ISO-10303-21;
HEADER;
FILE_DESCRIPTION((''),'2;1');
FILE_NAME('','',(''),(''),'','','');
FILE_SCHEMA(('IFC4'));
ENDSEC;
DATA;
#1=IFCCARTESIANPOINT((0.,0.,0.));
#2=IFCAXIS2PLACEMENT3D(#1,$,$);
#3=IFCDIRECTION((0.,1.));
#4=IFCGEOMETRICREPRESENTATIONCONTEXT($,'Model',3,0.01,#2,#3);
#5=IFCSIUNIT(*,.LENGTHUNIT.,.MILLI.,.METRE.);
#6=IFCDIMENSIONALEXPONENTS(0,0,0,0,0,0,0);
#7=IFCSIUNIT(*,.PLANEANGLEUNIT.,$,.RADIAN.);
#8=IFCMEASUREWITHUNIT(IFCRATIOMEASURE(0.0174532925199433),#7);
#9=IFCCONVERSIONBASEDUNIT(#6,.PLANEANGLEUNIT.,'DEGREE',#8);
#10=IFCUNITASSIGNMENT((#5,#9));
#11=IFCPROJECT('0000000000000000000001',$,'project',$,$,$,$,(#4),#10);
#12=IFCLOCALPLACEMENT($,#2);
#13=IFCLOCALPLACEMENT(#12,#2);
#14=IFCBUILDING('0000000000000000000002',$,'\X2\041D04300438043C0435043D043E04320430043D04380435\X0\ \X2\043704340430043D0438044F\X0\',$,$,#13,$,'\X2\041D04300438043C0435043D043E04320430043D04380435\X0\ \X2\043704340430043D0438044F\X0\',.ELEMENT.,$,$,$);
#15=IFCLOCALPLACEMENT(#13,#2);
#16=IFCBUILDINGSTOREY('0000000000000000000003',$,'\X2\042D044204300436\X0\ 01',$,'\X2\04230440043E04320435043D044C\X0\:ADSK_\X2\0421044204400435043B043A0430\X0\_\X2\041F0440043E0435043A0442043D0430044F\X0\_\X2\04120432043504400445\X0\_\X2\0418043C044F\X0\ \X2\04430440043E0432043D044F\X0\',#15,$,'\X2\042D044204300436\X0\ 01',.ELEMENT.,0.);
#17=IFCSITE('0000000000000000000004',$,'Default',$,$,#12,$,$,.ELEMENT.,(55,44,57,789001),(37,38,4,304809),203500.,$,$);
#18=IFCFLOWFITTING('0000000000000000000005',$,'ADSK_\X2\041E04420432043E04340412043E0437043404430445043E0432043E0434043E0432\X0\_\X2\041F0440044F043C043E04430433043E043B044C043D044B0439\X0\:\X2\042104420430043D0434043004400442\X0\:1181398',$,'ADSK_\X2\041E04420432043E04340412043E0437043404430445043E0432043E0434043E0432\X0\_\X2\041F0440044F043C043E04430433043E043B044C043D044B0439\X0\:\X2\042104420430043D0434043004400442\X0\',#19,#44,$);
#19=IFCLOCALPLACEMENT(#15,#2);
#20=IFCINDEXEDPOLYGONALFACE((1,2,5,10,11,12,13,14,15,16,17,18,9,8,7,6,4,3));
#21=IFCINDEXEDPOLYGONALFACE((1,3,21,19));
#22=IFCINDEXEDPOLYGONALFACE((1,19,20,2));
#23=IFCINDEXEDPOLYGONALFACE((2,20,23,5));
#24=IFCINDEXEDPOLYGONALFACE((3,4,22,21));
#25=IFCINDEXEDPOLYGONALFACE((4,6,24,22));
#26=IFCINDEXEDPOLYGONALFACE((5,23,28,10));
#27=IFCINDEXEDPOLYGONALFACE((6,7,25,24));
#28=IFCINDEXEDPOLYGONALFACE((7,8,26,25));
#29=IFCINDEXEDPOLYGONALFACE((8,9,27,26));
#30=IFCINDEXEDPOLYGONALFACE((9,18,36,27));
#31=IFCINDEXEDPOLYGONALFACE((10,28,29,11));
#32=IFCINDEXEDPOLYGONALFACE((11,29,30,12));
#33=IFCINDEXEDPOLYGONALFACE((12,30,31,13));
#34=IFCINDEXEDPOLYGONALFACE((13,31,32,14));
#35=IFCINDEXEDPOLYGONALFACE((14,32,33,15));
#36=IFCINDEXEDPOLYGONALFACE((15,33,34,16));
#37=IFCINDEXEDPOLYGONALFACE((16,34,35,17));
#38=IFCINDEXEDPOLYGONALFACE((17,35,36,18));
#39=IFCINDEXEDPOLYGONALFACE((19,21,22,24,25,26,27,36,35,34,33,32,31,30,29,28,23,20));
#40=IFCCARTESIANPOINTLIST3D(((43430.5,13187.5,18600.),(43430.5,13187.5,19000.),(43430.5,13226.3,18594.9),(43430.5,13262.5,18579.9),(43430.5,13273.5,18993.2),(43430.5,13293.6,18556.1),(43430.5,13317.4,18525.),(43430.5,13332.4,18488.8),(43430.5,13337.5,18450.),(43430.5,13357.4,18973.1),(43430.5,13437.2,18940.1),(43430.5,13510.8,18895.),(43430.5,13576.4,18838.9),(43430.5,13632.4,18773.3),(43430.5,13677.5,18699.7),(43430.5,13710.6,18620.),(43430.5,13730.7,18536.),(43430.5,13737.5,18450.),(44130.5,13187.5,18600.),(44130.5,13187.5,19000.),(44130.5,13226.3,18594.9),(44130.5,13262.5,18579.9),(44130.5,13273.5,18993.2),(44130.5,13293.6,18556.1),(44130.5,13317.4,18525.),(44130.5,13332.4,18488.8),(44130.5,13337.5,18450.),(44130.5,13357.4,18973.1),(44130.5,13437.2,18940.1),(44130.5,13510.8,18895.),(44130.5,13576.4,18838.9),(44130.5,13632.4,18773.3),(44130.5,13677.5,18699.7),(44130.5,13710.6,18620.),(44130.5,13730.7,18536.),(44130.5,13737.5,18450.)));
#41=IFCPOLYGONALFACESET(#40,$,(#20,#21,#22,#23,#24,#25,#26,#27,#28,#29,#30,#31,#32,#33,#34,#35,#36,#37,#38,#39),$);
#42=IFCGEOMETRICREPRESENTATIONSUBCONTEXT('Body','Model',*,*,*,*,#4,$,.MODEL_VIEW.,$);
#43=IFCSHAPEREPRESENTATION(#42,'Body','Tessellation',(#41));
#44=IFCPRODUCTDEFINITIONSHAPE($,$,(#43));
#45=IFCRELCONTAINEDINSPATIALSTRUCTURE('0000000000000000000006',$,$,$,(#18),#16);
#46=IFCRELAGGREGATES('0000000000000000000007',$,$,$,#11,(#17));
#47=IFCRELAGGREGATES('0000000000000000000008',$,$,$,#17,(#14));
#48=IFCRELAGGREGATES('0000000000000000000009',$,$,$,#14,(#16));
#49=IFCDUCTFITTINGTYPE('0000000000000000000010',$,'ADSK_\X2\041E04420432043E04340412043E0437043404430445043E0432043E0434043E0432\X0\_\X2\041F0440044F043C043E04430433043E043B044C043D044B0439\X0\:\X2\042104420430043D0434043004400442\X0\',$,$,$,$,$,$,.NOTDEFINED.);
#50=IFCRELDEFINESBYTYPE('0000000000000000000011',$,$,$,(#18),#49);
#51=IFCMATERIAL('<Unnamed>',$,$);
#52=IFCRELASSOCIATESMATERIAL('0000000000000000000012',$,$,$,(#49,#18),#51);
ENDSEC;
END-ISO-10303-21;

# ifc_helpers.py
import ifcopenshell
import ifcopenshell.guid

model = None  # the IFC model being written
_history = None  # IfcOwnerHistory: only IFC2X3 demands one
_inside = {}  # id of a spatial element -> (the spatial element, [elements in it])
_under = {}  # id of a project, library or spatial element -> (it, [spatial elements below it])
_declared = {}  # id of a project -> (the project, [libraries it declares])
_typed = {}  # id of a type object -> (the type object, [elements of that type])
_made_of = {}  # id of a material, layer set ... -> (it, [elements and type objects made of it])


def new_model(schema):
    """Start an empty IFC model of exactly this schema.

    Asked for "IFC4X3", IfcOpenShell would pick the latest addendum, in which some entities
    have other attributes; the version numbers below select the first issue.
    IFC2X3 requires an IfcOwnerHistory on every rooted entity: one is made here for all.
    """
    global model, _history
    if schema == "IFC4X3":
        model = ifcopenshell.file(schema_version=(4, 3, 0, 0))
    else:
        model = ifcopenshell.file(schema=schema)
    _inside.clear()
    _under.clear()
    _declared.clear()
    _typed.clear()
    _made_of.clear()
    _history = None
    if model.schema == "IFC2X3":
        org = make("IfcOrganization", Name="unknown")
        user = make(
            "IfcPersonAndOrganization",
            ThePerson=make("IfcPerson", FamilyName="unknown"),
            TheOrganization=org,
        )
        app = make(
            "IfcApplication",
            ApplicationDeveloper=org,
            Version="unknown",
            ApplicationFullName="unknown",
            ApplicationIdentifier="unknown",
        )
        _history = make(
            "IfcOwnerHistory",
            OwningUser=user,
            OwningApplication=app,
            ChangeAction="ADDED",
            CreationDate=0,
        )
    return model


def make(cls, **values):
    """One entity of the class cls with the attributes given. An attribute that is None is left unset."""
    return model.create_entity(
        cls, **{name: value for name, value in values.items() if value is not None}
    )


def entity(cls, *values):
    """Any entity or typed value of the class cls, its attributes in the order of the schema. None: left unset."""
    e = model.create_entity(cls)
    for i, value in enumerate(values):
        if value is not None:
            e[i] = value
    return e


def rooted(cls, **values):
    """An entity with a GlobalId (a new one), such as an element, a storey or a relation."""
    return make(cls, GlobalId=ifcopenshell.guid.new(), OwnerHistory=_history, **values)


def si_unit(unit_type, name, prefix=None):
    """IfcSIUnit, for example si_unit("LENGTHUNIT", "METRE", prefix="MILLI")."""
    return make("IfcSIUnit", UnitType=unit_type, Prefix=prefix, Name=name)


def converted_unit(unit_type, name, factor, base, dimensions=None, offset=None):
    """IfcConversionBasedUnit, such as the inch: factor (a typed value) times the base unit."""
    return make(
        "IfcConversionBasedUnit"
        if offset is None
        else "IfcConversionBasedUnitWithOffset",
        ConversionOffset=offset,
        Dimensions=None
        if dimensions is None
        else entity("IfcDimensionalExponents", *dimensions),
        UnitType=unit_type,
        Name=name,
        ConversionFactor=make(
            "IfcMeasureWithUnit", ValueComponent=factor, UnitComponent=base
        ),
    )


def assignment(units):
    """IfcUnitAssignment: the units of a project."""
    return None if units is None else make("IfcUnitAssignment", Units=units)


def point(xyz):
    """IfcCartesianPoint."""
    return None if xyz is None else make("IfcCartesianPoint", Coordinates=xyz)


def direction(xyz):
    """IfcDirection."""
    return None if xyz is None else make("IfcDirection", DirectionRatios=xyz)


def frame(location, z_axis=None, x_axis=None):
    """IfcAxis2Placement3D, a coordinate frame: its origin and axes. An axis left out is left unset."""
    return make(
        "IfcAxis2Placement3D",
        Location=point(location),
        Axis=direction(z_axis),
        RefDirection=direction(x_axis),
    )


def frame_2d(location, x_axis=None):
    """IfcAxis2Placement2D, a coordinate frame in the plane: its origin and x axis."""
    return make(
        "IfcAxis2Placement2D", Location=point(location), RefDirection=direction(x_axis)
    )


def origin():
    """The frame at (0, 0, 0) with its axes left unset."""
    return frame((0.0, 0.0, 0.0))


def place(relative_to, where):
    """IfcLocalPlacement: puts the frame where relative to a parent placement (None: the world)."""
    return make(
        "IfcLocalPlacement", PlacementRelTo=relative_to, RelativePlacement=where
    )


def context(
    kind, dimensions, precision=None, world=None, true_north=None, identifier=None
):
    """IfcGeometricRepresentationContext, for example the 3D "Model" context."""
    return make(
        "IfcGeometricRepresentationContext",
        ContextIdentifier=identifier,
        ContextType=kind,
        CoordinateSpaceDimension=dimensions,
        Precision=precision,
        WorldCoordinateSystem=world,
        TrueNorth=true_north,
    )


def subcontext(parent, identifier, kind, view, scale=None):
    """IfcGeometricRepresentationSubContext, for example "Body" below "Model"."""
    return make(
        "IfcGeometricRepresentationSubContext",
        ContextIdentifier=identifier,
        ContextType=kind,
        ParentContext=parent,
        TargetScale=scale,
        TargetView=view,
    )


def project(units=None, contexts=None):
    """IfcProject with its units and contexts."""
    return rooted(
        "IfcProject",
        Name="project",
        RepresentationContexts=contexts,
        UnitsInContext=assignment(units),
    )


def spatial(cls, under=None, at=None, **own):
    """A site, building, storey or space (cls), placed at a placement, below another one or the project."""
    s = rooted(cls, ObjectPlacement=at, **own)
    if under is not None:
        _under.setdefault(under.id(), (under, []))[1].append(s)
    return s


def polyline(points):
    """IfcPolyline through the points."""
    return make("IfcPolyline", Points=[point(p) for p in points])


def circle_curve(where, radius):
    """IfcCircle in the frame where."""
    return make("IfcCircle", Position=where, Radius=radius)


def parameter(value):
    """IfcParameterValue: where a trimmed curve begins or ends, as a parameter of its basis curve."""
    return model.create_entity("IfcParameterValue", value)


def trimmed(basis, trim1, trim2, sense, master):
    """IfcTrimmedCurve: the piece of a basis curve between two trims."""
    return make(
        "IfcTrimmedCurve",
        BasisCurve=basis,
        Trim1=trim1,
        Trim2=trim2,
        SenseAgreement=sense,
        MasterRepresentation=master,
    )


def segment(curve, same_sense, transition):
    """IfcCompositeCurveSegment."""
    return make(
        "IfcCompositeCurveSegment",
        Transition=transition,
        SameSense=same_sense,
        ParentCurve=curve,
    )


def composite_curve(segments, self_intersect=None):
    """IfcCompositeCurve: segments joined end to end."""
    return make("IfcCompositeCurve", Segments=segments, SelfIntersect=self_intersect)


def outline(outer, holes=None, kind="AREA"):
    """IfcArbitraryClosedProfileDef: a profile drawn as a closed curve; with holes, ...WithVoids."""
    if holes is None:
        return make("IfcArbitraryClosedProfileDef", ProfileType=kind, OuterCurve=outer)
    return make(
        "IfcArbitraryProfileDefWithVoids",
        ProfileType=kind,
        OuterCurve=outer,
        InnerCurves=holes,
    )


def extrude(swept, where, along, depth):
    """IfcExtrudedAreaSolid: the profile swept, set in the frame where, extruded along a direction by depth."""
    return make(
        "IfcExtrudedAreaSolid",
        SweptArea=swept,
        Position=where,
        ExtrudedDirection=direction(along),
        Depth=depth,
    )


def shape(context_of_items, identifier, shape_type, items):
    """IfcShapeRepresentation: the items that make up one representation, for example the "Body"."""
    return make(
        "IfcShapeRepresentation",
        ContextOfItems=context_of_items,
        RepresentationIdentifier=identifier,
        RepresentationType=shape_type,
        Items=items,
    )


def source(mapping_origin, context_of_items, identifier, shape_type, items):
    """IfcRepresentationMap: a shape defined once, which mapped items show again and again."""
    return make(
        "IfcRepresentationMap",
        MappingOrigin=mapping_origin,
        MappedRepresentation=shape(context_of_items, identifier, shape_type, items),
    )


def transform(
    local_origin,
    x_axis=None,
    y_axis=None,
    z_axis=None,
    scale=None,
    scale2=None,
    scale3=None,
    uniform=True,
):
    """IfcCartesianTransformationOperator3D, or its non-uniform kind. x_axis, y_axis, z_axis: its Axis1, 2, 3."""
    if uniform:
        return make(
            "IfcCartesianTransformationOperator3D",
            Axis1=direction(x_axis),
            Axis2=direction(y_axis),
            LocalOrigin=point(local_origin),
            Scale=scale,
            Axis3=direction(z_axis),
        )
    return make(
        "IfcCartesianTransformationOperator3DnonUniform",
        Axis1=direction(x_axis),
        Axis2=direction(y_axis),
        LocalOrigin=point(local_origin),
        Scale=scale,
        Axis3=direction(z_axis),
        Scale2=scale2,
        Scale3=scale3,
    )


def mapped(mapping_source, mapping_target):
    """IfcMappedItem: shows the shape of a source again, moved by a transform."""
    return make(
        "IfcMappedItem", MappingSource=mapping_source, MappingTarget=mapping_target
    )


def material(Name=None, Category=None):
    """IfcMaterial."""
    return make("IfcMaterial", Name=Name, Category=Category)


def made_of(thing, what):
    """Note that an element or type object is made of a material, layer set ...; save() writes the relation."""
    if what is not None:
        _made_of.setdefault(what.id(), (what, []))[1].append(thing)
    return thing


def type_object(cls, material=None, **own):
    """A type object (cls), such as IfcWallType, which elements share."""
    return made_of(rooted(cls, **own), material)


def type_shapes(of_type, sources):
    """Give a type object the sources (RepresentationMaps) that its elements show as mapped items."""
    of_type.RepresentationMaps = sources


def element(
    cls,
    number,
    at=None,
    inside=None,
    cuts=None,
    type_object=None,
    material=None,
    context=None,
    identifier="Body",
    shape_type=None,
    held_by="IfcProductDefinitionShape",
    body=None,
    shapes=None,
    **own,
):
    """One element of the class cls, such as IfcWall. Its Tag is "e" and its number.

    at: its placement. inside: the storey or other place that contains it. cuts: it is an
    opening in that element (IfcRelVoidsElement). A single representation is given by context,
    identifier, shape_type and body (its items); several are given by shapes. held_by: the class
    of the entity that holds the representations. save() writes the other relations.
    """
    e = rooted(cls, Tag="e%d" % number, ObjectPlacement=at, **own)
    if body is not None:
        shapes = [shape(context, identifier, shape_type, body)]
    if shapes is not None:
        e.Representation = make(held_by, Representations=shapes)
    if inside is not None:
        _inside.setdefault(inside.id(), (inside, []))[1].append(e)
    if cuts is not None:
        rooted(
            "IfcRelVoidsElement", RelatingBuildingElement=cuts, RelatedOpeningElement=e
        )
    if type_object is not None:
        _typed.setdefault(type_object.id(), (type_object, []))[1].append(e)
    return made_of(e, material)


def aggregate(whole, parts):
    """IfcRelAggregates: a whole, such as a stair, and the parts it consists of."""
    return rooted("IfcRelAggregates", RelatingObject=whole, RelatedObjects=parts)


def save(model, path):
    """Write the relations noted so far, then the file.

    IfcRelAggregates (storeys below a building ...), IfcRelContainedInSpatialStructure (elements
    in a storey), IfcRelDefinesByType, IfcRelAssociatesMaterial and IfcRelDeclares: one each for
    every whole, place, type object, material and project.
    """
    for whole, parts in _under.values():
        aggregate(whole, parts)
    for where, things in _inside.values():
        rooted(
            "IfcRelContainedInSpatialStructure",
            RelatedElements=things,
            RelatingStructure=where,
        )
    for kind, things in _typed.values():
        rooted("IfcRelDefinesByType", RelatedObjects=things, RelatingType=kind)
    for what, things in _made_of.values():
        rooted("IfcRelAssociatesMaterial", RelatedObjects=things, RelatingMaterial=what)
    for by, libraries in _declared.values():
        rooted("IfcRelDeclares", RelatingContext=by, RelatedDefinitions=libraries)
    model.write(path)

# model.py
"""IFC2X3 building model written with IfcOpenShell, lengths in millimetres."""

from ifc_helpers import new_model, entity, si_unit, converted_unit, direction, frame, frame_2d, origin, place, context, subcontext, project, spatial, polyline, circle_curve, parameter, trimmed, segment, composite_curve, outline, extrude, source, transform, mapped, material, type_object, type_shapes, element, save


model = new_model("IFC2X3")

# Units and contexts
model_context = context("Model", 3, precision=0.01, world=origin(), true_north=direction((0.0, 1.0)))
body_context = subcontext(model_context, "Body", "Model", "MODEL_VIEW")
ifc_project = project(units=[si_unit("LENGTHUNIT", "METRE", prefix="MILLI"), converted_unit("PLANEANGLEUNIT", "DEGREE", entity("IfcRatioMeasure", 0.0174532925199433), si_unit("PLANEANGLEUNIT", "RADIAN"), dimensions=[0, 0, 0, 0, 0, 0, 0])], contexts=[model_context])

# Site, building, storey
site_placement = place(None, origin())
site = spatial("IfcSite", under=ifc_project, at=site_placement, Name="Default", CompositionType="ELEMENT", RefLatitude=(55, 44, 57, 789001), RefLongitude=(37, 38, 4, 304809), RefElevation=203500.0)
building_placement = place(site_placement, origin())
building = spatial("IfcBuilding", under=site, at=building_placement, Name="Наименование здания", LongName="Наименование здания", CompositionType="ELEMENT")
storey_placement = place(building_placement, origin())
storey = spatial("IfcBuildingStorey", under=building, at=storey_placement, Name="Этаж 01", ObjectType="Уровень:ADSK_Стрелка_Проектная_Вверх_Имя уровня", LongName="Этаж 01", CompositionType="ELEMENT", Elevation=0.0)

# Shared definitions
ifc_material_1 = material(Name="<Unnamed>")

# Flow fitting
duct_fitting_type_1 = type_object("IfcDuctFittingType", Name="ADSK_ОтводВоздуховодов_Прямоугольный:Стандарт", PredefinedType="NOTDEFINED", material=ifc_material_1)
shared_shape_1 = source(origin(), body_context, "Body", "SweptSolid", [
    extrude(outline(composite_curve([segment(polyline([(-375.0, -175.0), (25.0, -175.0)]), True, "CONTINUOUS"), segment(trimmed(circle_curve(frame_2d((175.0, -175.0), x_axis=(0.0, 1.0)), 150.0), [parameter(0.0)], [parameter(90.0)], True, "PARAMETER"), False, "CONTINUOUS"), segment(polyline([(175.0, -25.0), (175.0, 375.0)]), True, "CONTINUOUS"), segment(trimmed(circle_curve(frame_2d((175.0, -175.0), x_axis=(0.0, 1.0)), 550.0), [parameter(0.0)], [parameter(90.0)], True, "PARAMETER"), True, "CONTINUOUS")], self_intersect=False)), frame((-175.0, 175.0, -350.0), z_axis=(0.0, 0.0, 1.0), x_axis=(-1.0, 0.0, 0.0)), (0.0, 0.0, 1.0), 700.0),
])
type_shapes(duct_fitting_type_1, [shared_shape_1])
flow_fitting_1_placement = place(storey_placement, frame((43780.5, 13537.5, 18800.0), z_axis=(1.0, 0.0, 0.0), x_axis=(0.0, 0.0, 1.0)))
element("IfcFlowFitting", 1, at=flow_fitting_1_placement, inside=storey, type_object=duct_fitting_type_1, material=ifc_material_1, Name="ADSK_ОтводВоздуховодов_Прямоугольный:Стандарт:1181398", ObjectType="ADSK_ОтводВоздуховодов_Прямоугольный:Стандарт", context=body_context, shape_type="MappedRepresentation", body=[
    mapped(shared_shape_1, transform((0.0, 0.0, 0.0), scale=1.0)),
])

save(model, "model.ifc")
